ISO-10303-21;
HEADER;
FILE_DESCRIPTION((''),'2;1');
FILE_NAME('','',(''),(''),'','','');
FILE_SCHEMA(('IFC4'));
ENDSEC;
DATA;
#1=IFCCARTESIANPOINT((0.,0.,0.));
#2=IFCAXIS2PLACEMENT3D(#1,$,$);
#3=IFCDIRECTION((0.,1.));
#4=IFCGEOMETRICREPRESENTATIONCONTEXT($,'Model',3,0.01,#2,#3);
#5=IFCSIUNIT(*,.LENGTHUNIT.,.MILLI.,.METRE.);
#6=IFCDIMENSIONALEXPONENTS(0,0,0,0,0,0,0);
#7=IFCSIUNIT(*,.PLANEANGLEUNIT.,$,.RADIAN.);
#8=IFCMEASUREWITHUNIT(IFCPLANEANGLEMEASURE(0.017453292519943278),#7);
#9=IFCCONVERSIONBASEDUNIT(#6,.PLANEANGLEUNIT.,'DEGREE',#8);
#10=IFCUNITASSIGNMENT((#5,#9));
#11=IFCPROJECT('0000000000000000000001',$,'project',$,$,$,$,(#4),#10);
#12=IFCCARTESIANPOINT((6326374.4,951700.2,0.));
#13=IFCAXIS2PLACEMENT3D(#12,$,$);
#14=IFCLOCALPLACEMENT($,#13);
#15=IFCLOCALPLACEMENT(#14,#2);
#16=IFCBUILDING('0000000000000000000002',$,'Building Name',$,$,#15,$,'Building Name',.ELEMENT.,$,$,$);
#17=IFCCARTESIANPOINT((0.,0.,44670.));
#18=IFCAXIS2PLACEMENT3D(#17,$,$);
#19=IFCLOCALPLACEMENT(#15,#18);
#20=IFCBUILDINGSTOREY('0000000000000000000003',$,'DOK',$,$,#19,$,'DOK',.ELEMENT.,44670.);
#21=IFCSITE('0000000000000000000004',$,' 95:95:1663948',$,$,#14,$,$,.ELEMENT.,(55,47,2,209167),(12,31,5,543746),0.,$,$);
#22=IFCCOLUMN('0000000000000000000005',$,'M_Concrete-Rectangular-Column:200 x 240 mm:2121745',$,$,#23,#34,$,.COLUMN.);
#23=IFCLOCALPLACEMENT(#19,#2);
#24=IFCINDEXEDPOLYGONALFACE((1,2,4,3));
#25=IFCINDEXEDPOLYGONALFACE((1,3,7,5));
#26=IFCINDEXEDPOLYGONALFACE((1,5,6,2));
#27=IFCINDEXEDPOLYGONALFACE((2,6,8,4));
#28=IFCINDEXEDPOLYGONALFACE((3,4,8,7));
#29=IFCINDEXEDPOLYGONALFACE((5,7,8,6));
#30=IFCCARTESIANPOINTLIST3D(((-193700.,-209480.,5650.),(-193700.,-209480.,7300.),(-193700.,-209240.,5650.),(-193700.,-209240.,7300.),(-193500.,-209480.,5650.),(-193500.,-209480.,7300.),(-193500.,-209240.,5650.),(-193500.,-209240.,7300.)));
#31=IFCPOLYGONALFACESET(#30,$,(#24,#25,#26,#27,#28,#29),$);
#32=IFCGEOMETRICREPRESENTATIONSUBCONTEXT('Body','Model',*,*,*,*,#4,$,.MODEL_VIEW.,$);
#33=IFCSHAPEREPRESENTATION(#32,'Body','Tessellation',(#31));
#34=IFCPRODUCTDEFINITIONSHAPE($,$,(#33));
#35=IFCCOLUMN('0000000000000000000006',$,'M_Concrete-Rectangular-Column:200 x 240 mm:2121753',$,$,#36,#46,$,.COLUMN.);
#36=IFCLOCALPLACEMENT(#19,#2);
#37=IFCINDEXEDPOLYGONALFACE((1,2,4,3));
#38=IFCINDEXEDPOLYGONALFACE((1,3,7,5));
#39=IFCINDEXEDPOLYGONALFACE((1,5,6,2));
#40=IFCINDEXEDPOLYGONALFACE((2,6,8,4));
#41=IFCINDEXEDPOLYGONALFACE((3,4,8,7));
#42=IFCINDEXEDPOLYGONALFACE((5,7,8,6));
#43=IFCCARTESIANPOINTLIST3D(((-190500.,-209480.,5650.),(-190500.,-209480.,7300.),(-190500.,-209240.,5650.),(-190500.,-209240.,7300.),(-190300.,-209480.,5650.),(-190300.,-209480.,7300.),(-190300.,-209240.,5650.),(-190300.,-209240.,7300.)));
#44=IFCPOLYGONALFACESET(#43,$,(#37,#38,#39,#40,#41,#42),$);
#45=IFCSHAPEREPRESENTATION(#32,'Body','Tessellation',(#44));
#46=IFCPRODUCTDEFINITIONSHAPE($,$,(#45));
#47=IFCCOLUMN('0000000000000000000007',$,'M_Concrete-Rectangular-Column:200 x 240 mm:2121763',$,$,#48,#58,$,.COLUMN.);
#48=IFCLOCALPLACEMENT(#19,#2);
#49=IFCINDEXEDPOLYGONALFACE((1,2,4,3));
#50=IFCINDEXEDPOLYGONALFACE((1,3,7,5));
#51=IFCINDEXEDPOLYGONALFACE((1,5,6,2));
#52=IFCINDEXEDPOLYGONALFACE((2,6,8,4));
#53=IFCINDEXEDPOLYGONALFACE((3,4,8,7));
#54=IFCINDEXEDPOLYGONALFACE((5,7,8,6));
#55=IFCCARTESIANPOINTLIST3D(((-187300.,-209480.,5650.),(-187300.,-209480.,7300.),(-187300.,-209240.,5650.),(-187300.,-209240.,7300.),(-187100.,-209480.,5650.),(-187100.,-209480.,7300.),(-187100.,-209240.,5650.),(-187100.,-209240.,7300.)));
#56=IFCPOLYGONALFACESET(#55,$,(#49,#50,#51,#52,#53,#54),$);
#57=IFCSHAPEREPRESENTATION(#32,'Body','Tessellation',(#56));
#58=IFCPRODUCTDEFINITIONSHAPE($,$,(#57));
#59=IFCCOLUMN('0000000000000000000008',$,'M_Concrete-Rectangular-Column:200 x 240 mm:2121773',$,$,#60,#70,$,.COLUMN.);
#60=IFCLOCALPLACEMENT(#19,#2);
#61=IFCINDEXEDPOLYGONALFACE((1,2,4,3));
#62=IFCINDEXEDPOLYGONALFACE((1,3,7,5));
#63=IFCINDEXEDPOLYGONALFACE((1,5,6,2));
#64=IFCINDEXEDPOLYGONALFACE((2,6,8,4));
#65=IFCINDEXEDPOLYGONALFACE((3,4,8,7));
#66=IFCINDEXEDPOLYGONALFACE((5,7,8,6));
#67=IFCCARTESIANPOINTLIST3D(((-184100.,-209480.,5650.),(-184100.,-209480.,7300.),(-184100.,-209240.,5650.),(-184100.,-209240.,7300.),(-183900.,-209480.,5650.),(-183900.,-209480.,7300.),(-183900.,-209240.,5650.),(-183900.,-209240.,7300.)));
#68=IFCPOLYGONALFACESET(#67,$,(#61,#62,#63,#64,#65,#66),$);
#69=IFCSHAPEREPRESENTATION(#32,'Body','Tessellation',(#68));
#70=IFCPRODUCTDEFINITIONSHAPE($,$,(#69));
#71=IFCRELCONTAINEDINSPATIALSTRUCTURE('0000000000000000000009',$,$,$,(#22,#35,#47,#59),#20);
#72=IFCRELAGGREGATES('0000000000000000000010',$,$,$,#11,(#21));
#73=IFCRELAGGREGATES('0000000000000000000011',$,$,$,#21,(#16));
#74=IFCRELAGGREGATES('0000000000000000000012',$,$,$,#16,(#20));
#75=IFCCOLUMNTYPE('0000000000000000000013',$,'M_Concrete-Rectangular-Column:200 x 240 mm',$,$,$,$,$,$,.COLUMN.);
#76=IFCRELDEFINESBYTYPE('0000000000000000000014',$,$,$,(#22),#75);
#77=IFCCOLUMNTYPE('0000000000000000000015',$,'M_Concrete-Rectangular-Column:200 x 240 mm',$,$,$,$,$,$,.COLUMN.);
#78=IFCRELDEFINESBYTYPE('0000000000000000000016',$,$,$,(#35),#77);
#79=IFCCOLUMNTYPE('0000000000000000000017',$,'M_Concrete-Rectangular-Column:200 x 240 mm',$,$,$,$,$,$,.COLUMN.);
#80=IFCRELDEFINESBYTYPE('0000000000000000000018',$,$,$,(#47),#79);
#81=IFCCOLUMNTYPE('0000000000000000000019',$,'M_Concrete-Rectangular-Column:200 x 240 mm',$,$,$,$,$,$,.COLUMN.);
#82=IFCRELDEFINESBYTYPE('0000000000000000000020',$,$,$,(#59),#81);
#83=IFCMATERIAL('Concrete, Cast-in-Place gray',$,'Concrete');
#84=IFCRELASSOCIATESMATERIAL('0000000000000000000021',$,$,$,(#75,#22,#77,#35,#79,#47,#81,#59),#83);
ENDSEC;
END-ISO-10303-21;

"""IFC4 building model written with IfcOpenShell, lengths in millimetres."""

from ifc_helpers import new_model, entity, si_unit, converted_unit, direction, frame, origin, place, context, subcontext, project, spatial, indexed_curve, outline, extrude, source, transform, mapped, material, type_object, type_shapes, element, save


model = new_model("IFC4")

# Units and contexts
model_context = context("Model", 3, precision=0.01, world=origin(), true_north=direction((0.0, 1.0)))
body_context = subcontext(model_context, "Body", "Model", "MODEL_VIEW")
ifc_project = project(units=[si_unit("LENGTHUNIT", "METRE", prefix="MILLI"), converted_unit("PLANEANGLEUNIT", "DEGREE", entity("IfcPlaneAngleMeasure", 0.017453292519943278), si_unit("PLANEANGLEUNIT", "RADIAN"), dimensions=[0, 0, 0, 0, 0, 0, 0])], contexts=[model_context])

# Site, building, storey
site_placement = place(None, frame((6326374.4, 951700.2, 0.0)))
site = spatial("IfcSite", under=ifc_project, at=site_placement, Name=" 95:95:1663948", CompositionType="ELEMENT", RefLatitude=(55, 47, 2, 209167), RefLongitude=(12, 31, 5, 543746), RefElevation=0.0)
building_placement = place(site_placement, origin())
building = spatial("IfcBuilding", under=site, at=building_placement, Name="Building Name", LongName="Building Name", CompositionType="ELEMENT")
storey_placement = place(building_placement, frame((0.0, 0.0, 44670.0)))
storey = spatial("IfcBuildingStorey", under=building, at=storey_placement, Name="DOK", LongName="DOK", CompositionType="ELEMENT", Elevation=44670.0)

# Columns
ifc_material_1 = material(Name="Concrete, Cast-in-Place gray", Category="Concrete")
column_type_1 = type_object("IfcColumnType", Name="M_Concrete-Rectangular-Column:200 x 240 mm", PredefinedType="COLUMN", material=ifc_material_1)
shared_shape_1 = source(origin(), body_context, "Body", "SweptSolid", [
    extrude(outline(indexed_curve([(-100.0, -120.0), (100.0, -120.0), (100.0, 120.0), (-100.0, 120.0), (-100.0, -120.0)], self_intersect=False)), frame((-193600.0, -209360.0, 50320.0), z_axis=(0.0, 0.0, 1.0), x_axis=(-1.0, 0.0, 0.0)), (0.0, 0.0, 1.0), 1650.0),
])
type_shapes(column_type_1, [shared_shape_1])
column_1_placement = place(storey_placement, frame((0.0, 0.0, -44670.0)))
element("IfcColumn", 1, at=column_1_placement, inside=storey, type_object=column_type_1, material=ifc_material_1, Name="M_Concrete-Rectangular-Column:200 x 240 mm:2121745", PredefinedType="COLUMN", context=body_context, shape_type="MappedRepresentation", body=[
    mapped(shared_shape_1, transform((0.0, 0.0, 0.0), scale=1.0)),
])
column_type_2 = type_object("IfcColumnType", Name="M_Concrete-Rectangular-Column:200 x 240 mm", PredefinedType="COLUMN", material=ifc_material_1)
shared_shape_2 = source(origin(), body_context, "Body", "SweptSolid", [
    extrude(outline(indexed_curve([(-100.0, -120.0), (100.0, -120.0), (100.0, 120.0), (-100.0, 120.0), (-100.0, -120.0)], self_intersect=False)), frame((-190400.0, -209360.0, 50320.0), z_axis=(0.0, 0.0, 1.0), x_axis=(-1.0, 0.0, 0.0)), (0.0, 0.0, 1.0), 1650.0),
])
type_shapes(column_type_2, [shared_shape_2])
column_2_placement = place(storey_placement, frame((0.0, 0.0, -44670.0)))
element("IfcColumn", 2, at=column_2_placement, inside=storey, type_object=column_type_2, material=ifc_material_1, Name="M_Concrete-Rectangular-Column:200 x 240 mm:2121753", PredefinedType="COLUMN", context=body_context, shape_type="MappedRepresentation", body=[
    mapped(shared_shape_2, transform((0.0, 0.0, 0.0), scale=1.0)),
])
column_type_3 = type_object("IfcColumnType", Name="M_Concrete-Rectangular-Column:200 x 240 mm", PredefinedType="COLUMN", material=ifc_material_1)
shared_shape_3 = source(origin(), body_context, "Body", "SweptSolid", [
    extrude(outline(indexed_curve([(-100.0, -120.0), (100.0, -120.0), (100.0, 120.0), (-100.0, 120.0), (-100.0, -120.0)], self_intersect=False)), frame((-187200.0, -209360.0, 50320.0), z_axis=(0.0, 0.0, 1.0), x_axis=(-1.0, 0.0, 0.0)), (0.0, 0.0, 1.0), 1650.0),
])
type_shapes(column_type_3, [shared_shape_3])
column_3_placement = place(storey_placement, frame((0.0, 0.0, -44670.0)))
element("IfcColumn", 3, at=column_3_placement, inside=storey, type_object=column_type_3, material=ifc_material_1, Name="M_Concrete-Rectangular-Column:200 x 240 mm:2121763", PredefinedType="COLUMN", context=body_context, shape_type="MappedRepresentation", body=[
    mapped(shared_shape_3, transform((0.0, 0.0, 0.0), scale=1.0)),
])
column_type_4 = type_object("IfcColumnType", Name="M_Concrete-Rectangular-Column:200 x 240 mm", PredefinedType="COLUMN", material=ifc_material_1)
shared_shape_4 = source(origin(), body_context, "Body", "SweptSolid", [
    extrude(outline(indexed_curve([(-100.0, -120.0), (100.0, -120.0), (100.0, 120.0), (-100.0, 120.0), (-100.0, -120.0)], self_intersect=False)), frame((-184000.0, -209360.0, 50320.0), z_axis=(0.0, 0.0, 1.0), x_axis=(-1.0, 0.0, 0.0)), (0.0, 0.0, 1.0), 1650.0),
])
type_shapes(column_type_4, [shared_shape_4])
column_4_placement = place(storey_placement, frame((0.0, 0.0, -44670.0)))
element("IfcColumn", 4, at=column_4_placement, inside=storey, type_object=column_type_4, material=ifc_material_1, Name="M_Concrete-Rectangular-Column:200 x 240 mm:2121773", PredefinedType="COLUMN", context=body_context, shape_type="MappedRepresentation", body=[
    mapped(shared_shape_4, transform((0.0, 0.0, 0.0), scale=1.0)),
])

save(model, "model.ifc")
